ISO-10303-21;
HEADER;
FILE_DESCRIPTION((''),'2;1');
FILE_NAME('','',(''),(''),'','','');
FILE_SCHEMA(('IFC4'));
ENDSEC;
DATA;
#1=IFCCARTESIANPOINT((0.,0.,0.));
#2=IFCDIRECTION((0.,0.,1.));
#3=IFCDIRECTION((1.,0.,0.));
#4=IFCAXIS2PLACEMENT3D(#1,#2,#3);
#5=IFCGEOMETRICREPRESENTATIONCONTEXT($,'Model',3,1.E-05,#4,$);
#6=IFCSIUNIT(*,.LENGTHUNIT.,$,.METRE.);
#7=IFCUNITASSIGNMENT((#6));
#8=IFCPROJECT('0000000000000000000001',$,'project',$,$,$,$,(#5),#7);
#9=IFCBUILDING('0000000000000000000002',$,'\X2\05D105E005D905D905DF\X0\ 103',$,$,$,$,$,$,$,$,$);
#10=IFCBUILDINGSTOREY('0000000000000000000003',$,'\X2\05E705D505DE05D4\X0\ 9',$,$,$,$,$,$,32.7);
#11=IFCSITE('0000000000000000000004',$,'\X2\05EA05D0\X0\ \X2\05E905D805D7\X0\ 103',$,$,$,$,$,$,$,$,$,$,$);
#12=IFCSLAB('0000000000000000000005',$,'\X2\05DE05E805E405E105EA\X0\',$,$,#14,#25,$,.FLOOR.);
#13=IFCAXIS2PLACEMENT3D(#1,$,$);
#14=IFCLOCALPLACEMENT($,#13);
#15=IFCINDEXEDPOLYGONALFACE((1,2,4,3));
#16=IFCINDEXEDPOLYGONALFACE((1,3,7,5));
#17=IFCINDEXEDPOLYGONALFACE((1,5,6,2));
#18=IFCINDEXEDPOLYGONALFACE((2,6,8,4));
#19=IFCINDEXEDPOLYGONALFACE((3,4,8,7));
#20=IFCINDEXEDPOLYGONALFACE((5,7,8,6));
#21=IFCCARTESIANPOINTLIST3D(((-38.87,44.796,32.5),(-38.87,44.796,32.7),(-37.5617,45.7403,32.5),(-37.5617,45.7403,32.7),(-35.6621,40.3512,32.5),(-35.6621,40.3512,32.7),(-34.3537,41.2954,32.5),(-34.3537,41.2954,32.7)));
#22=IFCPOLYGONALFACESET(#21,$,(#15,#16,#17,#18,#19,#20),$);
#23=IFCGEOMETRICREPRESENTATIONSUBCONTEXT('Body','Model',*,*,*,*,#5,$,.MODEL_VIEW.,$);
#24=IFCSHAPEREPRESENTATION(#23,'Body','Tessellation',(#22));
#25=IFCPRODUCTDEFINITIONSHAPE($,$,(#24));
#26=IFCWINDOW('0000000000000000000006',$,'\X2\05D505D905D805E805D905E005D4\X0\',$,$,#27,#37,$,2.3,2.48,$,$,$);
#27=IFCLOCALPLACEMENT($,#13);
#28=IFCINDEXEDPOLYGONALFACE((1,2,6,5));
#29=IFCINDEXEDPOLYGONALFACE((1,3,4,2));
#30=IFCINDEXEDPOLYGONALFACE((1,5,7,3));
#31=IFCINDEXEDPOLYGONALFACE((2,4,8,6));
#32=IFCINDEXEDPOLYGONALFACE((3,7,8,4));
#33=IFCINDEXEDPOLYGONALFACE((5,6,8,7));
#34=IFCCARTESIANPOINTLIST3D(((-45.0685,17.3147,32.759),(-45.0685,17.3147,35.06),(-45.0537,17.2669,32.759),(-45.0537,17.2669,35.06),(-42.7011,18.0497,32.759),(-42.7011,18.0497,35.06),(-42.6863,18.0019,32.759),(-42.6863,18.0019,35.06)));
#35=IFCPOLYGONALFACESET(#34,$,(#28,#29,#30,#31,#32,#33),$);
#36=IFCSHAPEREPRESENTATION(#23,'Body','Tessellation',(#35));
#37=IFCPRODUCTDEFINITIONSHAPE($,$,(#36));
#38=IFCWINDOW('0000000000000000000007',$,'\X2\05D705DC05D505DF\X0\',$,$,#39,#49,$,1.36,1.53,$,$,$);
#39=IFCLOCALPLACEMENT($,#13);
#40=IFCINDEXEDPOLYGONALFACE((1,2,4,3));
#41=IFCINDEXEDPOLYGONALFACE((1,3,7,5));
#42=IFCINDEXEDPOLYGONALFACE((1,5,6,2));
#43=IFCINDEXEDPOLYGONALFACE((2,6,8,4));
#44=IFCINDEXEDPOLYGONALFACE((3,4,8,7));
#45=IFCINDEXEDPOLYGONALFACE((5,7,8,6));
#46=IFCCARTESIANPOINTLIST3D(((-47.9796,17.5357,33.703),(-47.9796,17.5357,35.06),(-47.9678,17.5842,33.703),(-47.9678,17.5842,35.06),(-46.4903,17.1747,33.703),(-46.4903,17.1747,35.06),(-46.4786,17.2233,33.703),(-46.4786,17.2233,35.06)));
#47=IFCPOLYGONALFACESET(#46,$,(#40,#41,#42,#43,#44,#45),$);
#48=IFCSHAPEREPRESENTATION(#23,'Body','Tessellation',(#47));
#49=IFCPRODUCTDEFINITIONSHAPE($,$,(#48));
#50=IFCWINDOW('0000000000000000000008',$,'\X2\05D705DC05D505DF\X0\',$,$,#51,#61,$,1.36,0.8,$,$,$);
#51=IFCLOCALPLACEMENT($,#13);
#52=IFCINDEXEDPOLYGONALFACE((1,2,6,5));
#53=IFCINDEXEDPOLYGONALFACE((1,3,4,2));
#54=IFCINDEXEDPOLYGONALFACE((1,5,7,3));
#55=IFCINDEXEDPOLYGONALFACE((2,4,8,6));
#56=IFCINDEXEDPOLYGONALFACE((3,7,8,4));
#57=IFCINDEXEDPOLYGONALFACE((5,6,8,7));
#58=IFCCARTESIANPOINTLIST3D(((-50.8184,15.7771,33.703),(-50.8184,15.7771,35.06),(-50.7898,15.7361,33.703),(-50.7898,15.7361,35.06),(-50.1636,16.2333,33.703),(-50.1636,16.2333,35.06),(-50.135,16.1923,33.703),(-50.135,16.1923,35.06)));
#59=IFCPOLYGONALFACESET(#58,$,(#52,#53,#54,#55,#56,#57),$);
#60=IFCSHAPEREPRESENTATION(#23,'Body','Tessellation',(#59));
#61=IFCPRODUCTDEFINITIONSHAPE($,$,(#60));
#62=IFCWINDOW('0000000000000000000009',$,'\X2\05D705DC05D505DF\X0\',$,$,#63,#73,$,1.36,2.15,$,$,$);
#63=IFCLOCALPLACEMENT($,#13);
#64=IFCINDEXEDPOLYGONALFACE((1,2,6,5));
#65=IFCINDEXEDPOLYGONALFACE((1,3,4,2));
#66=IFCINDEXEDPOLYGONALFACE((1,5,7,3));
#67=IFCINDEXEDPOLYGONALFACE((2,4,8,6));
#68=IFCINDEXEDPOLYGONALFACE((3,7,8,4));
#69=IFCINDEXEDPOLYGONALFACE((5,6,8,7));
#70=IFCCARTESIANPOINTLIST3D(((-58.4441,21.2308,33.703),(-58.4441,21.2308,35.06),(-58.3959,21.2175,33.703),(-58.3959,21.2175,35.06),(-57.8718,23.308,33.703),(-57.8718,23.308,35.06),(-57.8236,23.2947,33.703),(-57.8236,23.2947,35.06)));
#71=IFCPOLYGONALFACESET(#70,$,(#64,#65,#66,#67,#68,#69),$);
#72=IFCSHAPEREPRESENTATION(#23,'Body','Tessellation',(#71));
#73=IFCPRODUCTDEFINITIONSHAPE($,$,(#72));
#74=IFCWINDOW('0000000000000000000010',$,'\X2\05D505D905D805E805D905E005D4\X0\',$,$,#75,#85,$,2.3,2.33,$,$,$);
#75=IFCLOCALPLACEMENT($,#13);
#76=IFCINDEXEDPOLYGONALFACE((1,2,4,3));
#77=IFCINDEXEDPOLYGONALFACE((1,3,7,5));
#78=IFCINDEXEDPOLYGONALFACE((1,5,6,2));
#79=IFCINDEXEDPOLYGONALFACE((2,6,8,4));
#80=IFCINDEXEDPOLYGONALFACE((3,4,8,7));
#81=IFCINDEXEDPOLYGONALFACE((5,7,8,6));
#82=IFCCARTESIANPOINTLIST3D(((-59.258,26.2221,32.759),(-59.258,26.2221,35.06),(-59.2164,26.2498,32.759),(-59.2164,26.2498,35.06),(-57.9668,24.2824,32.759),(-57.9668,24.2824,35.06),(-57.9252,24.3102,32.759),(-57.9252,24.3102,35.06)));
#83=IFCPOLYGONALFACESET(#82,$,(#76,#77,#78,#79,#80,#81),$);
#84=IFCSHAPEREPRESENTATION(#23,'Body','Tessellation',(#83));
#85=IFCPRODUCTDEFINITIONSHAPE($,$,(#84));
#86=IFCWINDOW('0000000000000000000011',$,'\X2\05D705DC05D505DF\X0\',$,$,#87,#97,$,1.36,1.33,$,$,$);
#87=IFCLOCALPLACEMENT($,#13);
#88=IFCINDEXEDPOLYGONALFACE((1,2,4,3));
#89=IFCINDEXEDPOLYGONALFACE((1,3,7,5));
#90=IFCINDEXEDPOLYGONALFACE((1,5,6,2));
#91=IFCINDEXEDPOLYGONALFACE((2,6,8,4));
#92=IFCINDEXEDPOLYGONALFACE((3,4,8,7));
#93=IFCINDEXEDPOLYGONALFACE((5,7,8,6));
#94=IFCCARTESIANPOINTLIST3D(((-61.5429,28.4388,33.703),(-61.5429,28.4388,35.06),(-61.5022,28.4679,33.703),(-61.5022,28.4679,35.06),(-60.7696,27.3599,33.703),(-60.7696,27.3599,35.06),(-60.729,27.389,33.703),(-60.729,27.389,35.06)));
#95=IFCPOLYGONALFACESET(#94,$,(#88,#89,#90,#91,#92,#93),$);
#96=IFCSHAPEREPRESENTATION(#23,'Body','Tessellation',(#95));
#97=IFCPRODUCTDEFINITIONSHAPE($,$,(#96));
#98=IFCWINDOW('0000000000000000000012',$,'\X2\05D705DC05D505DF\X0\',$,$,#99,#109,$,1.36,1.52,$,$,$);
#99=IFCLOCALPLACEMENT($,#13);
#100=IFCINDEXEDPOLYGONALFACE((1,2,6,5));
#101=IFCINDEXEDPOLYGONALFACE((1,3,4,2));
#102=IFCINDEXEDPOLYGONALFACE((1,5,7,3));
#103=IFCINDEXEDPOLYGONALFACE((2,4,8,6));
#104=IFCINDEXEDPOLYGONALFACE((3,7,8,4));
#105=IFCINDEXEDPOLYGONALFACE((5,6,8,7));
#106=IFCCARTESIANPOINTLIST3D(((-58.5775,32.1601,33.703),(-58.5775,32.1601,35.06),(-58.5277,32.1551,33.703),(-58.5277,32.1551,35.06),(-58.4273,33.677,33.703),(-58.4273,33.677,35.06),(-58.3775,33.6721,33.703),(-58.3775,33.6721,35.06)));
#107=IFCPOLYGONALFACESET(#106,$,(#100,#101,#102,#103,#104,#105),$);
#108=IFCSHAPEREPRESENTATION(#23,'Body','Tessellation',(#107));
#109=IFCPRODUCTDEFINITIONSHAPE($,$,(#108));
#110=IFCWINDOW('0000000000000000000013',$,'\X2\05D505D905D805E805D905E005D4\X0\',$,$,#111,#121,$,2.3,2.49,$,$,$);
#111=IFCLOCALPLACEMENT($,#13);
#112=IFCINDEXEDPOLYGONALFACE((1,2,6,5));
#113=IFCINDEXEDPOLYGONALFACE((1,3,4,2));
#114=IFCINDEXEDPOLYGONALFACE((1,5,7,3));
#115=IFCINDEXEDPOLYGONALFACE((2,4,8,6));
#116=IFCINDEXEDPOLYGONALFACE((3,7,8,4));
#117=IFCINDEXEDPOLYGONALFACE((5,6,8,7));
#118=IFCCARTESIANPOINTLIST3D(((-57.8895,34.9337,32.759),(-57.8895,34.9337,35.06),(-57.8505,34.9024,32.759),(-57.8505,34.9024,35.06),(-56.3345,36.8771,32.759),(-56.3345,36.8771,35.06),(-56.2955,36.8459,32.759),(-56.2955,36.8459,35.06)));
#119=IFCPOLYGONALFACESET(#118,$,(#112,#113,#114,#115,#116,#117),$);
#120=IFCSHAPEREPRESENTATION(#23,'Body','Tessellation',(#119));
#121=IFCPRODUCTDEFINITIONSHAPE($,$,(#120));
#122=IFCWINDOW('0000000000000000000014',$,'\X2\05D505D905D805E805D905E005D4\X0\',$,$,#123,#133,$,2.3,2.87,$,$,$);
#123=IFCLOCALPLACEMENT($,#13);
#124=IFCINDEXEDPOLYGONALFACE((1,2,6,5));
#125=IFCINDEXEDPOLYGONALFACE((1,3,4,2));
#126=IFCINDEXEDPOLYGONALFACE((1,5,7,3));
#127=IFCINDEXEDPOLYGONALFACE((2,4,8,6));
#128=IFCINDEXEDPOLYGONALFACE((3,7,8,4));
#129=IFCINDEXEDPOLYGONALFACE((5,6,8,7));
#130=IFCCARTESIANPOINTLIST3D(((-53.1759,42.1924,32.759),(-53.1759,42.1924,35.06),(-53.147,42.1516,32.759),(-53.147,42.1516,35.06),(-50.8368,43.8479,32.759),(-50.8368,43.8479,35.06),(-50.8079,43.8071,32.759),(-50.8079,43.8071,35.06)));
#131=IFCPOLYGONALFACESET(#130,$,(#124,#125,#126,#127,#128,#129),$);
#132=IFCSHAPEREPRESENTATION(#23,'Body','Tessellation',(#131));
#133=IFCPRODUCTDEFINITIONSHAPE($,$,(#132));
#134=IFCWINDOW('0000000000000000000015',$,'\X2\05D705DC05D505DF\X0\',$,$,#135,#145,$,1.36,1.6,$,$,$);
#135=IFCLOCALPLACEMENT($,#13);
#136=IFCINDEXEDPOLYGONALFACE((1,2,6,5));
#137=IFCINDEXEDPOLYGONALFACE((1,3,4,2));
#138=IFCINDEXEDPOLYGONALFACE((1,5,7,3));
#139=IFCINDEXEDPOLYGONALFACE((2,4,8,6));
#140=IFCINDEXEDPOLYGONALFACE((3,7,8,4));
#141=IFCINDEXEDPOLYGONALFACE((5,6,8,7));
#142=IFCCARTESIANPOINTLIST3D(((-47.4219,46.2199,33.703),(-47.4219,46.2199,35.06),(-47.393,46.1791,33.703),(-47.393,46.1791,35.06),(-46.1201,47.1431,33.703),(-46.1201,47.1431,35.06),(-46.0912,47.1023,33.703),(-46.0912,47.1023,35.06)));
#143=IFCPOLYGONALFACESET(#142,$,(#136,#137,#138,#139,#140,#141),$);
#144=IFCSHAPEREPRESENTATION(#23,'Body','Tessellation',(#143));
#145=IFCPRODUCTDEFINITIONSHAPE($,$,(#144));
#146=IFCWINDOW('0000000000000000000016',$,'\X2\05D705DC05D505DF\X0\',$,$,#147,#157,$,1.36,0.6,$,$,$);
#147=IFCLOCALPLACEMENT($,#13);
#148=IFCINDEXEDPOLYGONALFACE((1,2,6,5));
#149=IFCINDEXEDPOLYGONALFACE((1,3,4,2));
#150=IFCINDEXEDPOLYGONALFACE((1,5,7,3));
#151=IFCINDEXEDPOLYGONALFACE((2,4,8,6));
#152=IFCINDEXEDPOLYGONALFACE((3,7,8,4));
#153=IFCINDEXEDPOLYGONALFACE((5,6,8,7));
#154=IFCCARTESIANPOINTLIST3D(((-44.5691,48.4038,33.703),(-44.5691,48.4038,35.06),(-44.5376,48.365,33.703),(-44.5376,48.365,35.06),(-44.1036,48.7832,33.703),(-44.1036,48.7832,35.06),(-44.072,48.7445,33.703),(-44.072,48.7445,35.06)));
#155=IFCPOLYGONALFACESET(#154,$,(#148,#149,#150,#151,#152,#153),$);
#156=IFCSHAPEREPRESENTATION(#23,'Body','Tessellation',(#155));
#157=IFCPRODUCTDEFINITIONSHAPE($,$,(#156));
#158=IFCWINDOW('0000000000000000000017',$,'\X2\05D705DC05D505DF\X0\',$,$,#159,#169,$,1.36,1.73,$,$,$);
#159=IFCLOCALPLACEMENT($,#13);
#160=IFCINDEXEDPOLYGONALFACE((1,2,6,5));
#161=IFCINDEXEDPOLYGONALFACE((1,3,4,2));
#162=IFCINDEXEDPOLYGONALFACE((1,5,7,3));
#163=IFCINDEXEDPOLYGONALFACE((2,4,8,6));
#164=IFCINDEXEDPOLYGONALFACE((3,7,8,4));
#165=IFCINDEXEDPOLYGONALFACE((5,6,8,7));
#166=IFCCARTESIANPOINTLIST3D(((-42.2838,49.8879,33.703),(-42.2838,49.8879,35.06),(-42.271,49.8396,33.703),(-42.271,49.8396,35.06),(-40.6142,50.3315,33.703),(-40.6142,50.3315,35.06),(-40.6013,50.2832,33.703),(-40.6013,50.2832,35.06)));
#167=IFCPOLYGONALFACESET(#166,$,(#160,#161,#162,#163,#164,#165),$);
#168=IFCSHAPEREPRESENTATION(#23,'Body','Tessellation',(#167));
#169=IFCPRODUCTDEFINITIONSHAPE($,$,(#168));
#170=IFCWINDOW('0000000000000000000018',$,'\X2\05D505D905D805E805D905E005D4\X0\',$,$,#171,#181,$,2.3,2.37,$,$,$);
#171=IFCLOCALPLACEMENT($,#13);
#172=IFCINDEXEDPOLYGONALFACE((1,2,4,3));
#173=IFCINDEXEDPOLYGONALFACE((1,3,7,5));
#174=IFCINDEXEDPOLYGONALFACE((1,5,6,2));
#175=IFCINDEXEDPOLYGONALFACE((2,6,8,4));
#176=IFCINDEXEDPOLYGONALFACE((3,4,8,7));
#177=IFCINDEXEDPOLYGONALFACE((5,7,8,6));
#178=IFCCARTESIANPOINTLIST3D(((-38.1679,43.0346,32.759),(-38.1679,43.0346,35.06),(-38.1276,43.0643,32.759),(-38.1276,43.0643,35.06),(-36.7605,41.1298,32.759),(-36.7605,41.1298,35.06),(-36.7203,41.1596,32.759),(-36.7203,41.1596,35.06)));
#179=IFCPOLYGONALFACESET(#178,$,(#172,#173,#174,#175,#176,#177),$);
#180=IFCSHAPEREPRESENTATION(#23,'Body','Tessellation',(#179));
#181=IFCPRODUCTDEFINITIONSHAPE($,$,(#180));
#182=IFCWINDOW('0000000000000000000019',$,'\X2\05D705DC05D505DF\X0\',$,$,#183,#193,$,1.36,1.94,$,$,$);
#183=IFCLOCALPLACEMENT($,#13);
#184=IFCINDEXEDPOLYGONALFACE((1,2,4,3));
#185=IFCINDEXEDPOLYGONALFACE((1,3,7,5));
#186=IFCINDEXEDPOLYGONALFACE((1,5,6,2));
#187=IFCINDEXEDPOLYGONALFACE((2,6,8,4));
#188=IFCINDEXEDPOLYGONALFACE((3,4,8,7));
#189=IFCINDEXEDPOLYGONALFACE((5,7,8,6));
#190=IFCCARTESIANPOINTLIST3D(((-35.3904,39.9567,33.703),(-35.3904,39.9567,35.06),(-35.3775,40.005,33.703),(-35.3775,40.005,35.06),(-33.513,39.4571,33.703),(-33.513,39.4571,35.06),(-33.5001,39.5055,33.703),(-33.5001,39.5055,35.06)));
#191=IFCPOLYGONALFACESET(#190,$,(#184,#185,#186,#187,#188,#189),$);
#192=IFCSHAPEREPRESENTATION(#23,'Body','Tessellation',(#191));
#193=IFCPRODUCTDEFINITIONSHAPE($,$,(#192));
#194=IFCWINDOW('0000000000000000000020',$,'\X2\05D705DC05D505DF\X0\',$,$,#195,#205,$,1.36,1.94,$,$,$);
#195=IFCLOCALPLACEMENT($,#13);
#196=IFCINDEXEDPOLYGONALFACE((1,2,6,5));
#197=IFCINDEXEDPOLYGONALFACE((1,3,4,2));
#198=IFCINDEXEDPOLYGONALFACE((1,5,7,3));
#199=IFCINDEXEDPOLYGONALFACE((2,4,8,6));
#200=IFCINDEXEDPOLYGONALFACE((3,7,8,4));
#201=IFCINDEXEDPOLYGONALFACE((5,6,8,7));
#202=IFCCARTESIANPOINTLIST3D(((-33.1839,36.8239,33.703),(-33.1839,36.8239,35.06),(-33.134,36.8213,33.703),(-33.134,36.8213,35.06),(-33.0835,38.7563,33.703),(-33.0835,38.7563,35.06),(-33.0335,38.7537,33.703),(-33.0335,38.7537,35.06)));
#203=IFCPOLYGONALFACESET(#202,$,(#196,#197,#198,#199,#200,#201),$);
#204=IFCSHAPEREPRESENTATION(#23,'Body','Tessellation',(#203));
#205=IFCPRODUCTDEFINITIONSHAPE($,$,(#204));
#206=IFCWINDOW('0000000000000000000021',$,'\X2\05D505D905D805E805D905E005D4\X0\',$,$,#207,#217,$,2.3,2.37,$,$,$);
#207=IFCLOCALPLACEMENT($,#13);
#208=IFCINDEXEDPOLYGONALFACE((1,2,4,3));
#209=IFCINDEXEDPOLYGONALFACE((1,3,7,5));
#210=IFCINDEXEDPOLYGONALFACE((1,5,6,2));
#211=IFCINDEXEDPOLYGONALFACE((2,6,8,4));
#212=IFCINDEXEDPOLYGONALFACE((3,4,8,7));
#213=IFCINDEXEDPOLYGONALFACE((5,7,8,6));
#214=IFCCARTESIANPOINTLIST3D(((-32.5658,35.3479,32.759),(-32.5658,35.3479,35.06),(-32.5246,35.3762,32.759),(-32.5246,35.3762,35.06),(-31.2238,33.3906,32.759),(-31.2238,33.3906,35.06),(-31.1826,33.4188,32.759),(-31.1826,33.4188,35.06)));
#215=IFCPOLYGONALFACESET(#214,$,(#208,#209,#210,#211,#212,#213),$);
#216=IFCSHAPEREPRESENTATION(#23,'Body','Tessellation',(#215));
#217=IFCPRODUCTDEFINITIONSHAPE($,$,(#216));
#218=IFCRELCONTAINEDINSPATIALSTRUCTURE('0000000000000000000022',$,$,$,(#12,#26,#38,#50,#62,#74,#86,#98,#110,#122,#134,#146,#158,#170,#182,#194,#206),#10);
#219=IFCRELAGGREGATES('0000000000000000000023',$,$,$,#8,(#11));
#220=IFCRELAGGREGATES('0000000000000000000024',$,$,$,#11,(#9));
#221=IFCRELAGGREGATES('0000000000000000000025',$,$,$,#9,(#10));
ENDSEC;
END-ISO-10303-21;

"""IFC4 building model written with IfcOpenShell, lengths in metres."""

from ifc_helpers import new_model, si_unit, frame, origin_with_axes, context, subcontext, project, spatial, polyline, outline, extrude, element, save


model = new_model("IFC4")

# Units and contexts
model_context = context("Model", 3, precision=1e-05, world=origin_with_axes())
body_context = subcontext(model_context, "Body", "Model", "MODEL_VIEW")
ifc_project = project(units=[si_unit("LENGTHUNIT", "METRE")], contexts=[model_context])

# Site, building, storey
site = spatial("IfcSite", under=ifc_project, Name="תא שטח 103")
building = spatial("IfcBuilding", under=site, Name="בניין 103")
storey = spatial("IfcBuildingStorey", under=building, Name="קומה 9", Elevation=32.7)

# Slab
element("IfcSlab", 1, inside=storey, Name="מרפסת", PredefinedType="FLOOR", context=body_context, shape_type="SweptSolid", body=[
    extrude(outline(polyline([(-34.3537, 41.2954), (-37.5617, 45.7403), (-38.87, 44.796), (-35.6621, 40.3512), (-34.3537, 41.2954)])), frame((0.0, 0.0, 32.5)), (0.0, 0.0, 1.0), 0.2),
])

# Windows
element("IfcWindow", 2, inside=storey, Name="ויטרינה", OverallHeight=2.3, OverallWidth=2.48, context=body_context, shape_type="SweptSolid", body=[
    extrude(outline(polyline([(-42.7011, 18.0497), (-45.0685, 17.3147), (-45.0537, 17.2669), (-42.6863, 18.0019), (-42.7011, 18.0497)])), frame((0.0, 0.0, 32.759)), (0.0, 0.0, 1.0), 2.301),
])
element("IfcWindow", 3, inside=storey, Name="חלון", OverallHeight=1.36, OverallWidth=1.53, context=body_context, shape_type="SweptSolid", body=[
    extrude(outline(polyline([(-46.4786, 17.2233), (-47.9678, 17.5842), (-47.9796, 17.5357), (-46.4903, 17.1747), (-46.4786, 17.2233)])), frame((0.0, 0.0, 33.703)), (0.0, 0.0, 1.0), 1.357),
])
element("IfcWindow", 4, inside=storey, Name="חלון", OverallHeight=1.36, OverallWidth=0.8, context=body_context, shape_type="SweptSolid", body=[
    extrude(outline(polyline([(-50.1636, 16.2333), (-50.8184, 15.7771), (-50.7898, 15.7361), (-50.135, 16.1923), (-50.1636, 16.2333)])), frame((0.0, 0.0, 33.703)), (0.0, 0.0, 1.0), 1.357),
])
element("IfcWindow", 5, inside=storey, Name="חלון", OverallHeight=1.36, OverallWidth=2.15, context=body_context, shape_type="SweptSolid", body=[
    extrude(outline(polyline([(-58.3959, 21.2175), (-57.8236, 23.2947), (-57.8718, 23.308), (-58.4441, 21.2308), (-58.3959, 21.2175)])), frame((0.0, 0.0, 33.703)), (0.0, 0.0, 1.0), 1.357),
])
element("IfcWindow", 6, inside=storey, Name="ויטרינה", OverallHeight=2.3, OverallWidth=2.33, context=body_context, shape_type="SweptSolid", body=[
    extrude(outline(polyline([(-57.9252, 24.3102), (-59.2164, 26.2498), (-59.258, 26.2221), (-57.9668, 24.2824), (-57.9252, 24.3102)])), frame((0.0, 0.0, 32.759)), (0.0, 0.0, 1.0), 2.301),
])
element("IfcWindow", 7, inside=storey, Name="חלון", OverallHeight=1.36, OverallWidth=1.33, context=body_context, shape_type="SweptSolid", body=[
    extrude(outline(polyline([(-60.729, 27.389), (-61.5022, 28.4679), (-61.5429, 28.4388), (-60.7696, 27.3599), (-60.729, 27.389)])), frame((0.0, 0.0, 33.703)), (0.0, 0.0, 1.0), 1.357),
])
element("IfcWindow", 8, inside=storey, Name="חלון", OverallHeight=1.36, OverallWidth=1.52, context=body_context, shape_type="SweptSolid", body=[
    extrude(outline(polyline([(-58.5277, 32.1551), (-58.3775, 33.6721), (-58.4273, 33.677), (-58.5775, 32.1601), (-58.5277, 32.1551)])), frame((0.0, 0.0, 33.703)), (0.0, 0.0, 1.0), 1.357),
])
element("IfcWindow", 9, inside=storey, Name="ויטרינה", OverallHeight=2.3, OverallWidth=2.49, context=body_context, shape_type="SweptSolid", body=[
    extrude(outline(polyline([(-57.8505, 34.9024), (-56.2955, 36.8459), (-56.3345, 36.8771), (-57.8895, 34.9337), (-57.8505, 34.9024)])), frame((0.0, 0.0, 32.759)), (0.0, 0.0, 1.0), 2.301),
])
element("IfcWindow", 10, inside=storey, Name="ויטרינה", OverallHeight=2.3, OverallWidth=2.87, context=body_context, shape_type="SweptSolid", body=[
    extrude(outline(polyline([(-53.147, 42.1516), (-50.8079, 43.8071), (-50.8368, 43.8479), (-53.1759, 42.1924), (-53.147, 42.1516)])), frame((0.0, 0.0, 32.759)), (0.0, 0.0, 1.0), 2.301),
])
element("IfcWindow", 11, inside=storey, Name="חלון", OverallHeight=1.36, OverallWidth=1.6, context=body_context, shape_type="SweptSolid", body=[
    extrude(outline(polyline([(-47.393, 46.1791), (-46.0912, 47.1023), (-46.1201, 47.1431), (-47.4219, 46.2199), (-47.393, 46.1791)])), frame((0.0, 0.0, 33.703)), (0.0, 0.0, 1.0), 1.357),
])
element("IfcWindow", 12, inside=storey, Name="חלון", OverallHeight=1.36, OverallWidth=0.6, context=body_context, shape_type="SweptSolid", body=[
    extrude(outline(polyline([(-44.5376, 48.365), (-44.072, 48.7445), (-44.1036, 48.7832), (-44.5691, 48.4038), (-44.5376, 48.365)])), frame((0.0, 0.0, 33.703)), (0.0, 0.0, 1.0), 1.357),
])
element("IfcWindow", 13, inside=storey, Name="חלון", OverallHeight=1.36, OverallWidth=1.73, context=body_context, shape_type="SweptSolid", body=[
    extrude(outline(polyline([(-42.271, 49.8396), (-40.6013, 50.2832), (-40.6142, 50.3315), (-42.2838, 49.8879), (-42.271, 49.8396)])), frame((0.0, 0.0, 33.703)), (0.0, 0.0, 1.0), 1.357),
])
element("IfcWindow", 14, inside=storey, Name="ויטרינה", OverallHeight=2.3, OverallWidth=2.37, context=body_context, shape_type="SweptSolid", body=[
    extrude(outline(polyline([(-38.1679, 43.0346), (-36.7605, 41.1298), (-36.7203, 41.1596), (-38.1276, 43.0643), (-38.1679, 43.0346)])), frame((0.0, 0.0, 32.759)), (0.0, 0.0, 1.0), 2.301),
])
element("IfcWindow", 15, inside=storey, Name="חלון", OverallHeight=1.36, OverallWidth=1.94, context=body_context, shape_type="SweptSolid", body=[
    extrude(outline(polyline([(-35.3904, 39.9567), (-33.513, 39.4571), (-33.5001, 39.5055), (-35.3775, 40.005), (-35.3904, 39.9567)])), frame((0.0, 0.0, 33.703)), (0.0, 0.0, 1.0), 1.357),
])
element("IfcWindow", 16, inside=storey, Name="חלון", OverallHeight=1.36, OverallWidth=1.94, context=body_context, shape_type="SweptSolid", body=[
    extrude(outline(polyline([(-33.0835, 38.7563), (-33.1839, 36.8239), (-33.134, 36.8213), (-33.0335, 38.7537), (-33.0835, 38.7563)])), frame((0.0, 0.0, 33.703)), (0.0, 0.0, 1.0), 1.357),
])
element("IfcWindow", 17, inside=storey, Name="ויטרינה", OverallHeight=2.3, OverallWidth=2.37, context=body_context, shape_type="SweptSolid", body=[
    extrude(outline(polyline([(-32.5658, 35.3479), (-31.2238, 33.3906), (-31.1826, 33.4188), (-32.5246, 35.3762), (-32.5658, 35.3479)])), frame((0.0, 0.0, 32.759)), (0.0, 0.0, 1.0), 2.301),
])

save(model, "model.ifc")
